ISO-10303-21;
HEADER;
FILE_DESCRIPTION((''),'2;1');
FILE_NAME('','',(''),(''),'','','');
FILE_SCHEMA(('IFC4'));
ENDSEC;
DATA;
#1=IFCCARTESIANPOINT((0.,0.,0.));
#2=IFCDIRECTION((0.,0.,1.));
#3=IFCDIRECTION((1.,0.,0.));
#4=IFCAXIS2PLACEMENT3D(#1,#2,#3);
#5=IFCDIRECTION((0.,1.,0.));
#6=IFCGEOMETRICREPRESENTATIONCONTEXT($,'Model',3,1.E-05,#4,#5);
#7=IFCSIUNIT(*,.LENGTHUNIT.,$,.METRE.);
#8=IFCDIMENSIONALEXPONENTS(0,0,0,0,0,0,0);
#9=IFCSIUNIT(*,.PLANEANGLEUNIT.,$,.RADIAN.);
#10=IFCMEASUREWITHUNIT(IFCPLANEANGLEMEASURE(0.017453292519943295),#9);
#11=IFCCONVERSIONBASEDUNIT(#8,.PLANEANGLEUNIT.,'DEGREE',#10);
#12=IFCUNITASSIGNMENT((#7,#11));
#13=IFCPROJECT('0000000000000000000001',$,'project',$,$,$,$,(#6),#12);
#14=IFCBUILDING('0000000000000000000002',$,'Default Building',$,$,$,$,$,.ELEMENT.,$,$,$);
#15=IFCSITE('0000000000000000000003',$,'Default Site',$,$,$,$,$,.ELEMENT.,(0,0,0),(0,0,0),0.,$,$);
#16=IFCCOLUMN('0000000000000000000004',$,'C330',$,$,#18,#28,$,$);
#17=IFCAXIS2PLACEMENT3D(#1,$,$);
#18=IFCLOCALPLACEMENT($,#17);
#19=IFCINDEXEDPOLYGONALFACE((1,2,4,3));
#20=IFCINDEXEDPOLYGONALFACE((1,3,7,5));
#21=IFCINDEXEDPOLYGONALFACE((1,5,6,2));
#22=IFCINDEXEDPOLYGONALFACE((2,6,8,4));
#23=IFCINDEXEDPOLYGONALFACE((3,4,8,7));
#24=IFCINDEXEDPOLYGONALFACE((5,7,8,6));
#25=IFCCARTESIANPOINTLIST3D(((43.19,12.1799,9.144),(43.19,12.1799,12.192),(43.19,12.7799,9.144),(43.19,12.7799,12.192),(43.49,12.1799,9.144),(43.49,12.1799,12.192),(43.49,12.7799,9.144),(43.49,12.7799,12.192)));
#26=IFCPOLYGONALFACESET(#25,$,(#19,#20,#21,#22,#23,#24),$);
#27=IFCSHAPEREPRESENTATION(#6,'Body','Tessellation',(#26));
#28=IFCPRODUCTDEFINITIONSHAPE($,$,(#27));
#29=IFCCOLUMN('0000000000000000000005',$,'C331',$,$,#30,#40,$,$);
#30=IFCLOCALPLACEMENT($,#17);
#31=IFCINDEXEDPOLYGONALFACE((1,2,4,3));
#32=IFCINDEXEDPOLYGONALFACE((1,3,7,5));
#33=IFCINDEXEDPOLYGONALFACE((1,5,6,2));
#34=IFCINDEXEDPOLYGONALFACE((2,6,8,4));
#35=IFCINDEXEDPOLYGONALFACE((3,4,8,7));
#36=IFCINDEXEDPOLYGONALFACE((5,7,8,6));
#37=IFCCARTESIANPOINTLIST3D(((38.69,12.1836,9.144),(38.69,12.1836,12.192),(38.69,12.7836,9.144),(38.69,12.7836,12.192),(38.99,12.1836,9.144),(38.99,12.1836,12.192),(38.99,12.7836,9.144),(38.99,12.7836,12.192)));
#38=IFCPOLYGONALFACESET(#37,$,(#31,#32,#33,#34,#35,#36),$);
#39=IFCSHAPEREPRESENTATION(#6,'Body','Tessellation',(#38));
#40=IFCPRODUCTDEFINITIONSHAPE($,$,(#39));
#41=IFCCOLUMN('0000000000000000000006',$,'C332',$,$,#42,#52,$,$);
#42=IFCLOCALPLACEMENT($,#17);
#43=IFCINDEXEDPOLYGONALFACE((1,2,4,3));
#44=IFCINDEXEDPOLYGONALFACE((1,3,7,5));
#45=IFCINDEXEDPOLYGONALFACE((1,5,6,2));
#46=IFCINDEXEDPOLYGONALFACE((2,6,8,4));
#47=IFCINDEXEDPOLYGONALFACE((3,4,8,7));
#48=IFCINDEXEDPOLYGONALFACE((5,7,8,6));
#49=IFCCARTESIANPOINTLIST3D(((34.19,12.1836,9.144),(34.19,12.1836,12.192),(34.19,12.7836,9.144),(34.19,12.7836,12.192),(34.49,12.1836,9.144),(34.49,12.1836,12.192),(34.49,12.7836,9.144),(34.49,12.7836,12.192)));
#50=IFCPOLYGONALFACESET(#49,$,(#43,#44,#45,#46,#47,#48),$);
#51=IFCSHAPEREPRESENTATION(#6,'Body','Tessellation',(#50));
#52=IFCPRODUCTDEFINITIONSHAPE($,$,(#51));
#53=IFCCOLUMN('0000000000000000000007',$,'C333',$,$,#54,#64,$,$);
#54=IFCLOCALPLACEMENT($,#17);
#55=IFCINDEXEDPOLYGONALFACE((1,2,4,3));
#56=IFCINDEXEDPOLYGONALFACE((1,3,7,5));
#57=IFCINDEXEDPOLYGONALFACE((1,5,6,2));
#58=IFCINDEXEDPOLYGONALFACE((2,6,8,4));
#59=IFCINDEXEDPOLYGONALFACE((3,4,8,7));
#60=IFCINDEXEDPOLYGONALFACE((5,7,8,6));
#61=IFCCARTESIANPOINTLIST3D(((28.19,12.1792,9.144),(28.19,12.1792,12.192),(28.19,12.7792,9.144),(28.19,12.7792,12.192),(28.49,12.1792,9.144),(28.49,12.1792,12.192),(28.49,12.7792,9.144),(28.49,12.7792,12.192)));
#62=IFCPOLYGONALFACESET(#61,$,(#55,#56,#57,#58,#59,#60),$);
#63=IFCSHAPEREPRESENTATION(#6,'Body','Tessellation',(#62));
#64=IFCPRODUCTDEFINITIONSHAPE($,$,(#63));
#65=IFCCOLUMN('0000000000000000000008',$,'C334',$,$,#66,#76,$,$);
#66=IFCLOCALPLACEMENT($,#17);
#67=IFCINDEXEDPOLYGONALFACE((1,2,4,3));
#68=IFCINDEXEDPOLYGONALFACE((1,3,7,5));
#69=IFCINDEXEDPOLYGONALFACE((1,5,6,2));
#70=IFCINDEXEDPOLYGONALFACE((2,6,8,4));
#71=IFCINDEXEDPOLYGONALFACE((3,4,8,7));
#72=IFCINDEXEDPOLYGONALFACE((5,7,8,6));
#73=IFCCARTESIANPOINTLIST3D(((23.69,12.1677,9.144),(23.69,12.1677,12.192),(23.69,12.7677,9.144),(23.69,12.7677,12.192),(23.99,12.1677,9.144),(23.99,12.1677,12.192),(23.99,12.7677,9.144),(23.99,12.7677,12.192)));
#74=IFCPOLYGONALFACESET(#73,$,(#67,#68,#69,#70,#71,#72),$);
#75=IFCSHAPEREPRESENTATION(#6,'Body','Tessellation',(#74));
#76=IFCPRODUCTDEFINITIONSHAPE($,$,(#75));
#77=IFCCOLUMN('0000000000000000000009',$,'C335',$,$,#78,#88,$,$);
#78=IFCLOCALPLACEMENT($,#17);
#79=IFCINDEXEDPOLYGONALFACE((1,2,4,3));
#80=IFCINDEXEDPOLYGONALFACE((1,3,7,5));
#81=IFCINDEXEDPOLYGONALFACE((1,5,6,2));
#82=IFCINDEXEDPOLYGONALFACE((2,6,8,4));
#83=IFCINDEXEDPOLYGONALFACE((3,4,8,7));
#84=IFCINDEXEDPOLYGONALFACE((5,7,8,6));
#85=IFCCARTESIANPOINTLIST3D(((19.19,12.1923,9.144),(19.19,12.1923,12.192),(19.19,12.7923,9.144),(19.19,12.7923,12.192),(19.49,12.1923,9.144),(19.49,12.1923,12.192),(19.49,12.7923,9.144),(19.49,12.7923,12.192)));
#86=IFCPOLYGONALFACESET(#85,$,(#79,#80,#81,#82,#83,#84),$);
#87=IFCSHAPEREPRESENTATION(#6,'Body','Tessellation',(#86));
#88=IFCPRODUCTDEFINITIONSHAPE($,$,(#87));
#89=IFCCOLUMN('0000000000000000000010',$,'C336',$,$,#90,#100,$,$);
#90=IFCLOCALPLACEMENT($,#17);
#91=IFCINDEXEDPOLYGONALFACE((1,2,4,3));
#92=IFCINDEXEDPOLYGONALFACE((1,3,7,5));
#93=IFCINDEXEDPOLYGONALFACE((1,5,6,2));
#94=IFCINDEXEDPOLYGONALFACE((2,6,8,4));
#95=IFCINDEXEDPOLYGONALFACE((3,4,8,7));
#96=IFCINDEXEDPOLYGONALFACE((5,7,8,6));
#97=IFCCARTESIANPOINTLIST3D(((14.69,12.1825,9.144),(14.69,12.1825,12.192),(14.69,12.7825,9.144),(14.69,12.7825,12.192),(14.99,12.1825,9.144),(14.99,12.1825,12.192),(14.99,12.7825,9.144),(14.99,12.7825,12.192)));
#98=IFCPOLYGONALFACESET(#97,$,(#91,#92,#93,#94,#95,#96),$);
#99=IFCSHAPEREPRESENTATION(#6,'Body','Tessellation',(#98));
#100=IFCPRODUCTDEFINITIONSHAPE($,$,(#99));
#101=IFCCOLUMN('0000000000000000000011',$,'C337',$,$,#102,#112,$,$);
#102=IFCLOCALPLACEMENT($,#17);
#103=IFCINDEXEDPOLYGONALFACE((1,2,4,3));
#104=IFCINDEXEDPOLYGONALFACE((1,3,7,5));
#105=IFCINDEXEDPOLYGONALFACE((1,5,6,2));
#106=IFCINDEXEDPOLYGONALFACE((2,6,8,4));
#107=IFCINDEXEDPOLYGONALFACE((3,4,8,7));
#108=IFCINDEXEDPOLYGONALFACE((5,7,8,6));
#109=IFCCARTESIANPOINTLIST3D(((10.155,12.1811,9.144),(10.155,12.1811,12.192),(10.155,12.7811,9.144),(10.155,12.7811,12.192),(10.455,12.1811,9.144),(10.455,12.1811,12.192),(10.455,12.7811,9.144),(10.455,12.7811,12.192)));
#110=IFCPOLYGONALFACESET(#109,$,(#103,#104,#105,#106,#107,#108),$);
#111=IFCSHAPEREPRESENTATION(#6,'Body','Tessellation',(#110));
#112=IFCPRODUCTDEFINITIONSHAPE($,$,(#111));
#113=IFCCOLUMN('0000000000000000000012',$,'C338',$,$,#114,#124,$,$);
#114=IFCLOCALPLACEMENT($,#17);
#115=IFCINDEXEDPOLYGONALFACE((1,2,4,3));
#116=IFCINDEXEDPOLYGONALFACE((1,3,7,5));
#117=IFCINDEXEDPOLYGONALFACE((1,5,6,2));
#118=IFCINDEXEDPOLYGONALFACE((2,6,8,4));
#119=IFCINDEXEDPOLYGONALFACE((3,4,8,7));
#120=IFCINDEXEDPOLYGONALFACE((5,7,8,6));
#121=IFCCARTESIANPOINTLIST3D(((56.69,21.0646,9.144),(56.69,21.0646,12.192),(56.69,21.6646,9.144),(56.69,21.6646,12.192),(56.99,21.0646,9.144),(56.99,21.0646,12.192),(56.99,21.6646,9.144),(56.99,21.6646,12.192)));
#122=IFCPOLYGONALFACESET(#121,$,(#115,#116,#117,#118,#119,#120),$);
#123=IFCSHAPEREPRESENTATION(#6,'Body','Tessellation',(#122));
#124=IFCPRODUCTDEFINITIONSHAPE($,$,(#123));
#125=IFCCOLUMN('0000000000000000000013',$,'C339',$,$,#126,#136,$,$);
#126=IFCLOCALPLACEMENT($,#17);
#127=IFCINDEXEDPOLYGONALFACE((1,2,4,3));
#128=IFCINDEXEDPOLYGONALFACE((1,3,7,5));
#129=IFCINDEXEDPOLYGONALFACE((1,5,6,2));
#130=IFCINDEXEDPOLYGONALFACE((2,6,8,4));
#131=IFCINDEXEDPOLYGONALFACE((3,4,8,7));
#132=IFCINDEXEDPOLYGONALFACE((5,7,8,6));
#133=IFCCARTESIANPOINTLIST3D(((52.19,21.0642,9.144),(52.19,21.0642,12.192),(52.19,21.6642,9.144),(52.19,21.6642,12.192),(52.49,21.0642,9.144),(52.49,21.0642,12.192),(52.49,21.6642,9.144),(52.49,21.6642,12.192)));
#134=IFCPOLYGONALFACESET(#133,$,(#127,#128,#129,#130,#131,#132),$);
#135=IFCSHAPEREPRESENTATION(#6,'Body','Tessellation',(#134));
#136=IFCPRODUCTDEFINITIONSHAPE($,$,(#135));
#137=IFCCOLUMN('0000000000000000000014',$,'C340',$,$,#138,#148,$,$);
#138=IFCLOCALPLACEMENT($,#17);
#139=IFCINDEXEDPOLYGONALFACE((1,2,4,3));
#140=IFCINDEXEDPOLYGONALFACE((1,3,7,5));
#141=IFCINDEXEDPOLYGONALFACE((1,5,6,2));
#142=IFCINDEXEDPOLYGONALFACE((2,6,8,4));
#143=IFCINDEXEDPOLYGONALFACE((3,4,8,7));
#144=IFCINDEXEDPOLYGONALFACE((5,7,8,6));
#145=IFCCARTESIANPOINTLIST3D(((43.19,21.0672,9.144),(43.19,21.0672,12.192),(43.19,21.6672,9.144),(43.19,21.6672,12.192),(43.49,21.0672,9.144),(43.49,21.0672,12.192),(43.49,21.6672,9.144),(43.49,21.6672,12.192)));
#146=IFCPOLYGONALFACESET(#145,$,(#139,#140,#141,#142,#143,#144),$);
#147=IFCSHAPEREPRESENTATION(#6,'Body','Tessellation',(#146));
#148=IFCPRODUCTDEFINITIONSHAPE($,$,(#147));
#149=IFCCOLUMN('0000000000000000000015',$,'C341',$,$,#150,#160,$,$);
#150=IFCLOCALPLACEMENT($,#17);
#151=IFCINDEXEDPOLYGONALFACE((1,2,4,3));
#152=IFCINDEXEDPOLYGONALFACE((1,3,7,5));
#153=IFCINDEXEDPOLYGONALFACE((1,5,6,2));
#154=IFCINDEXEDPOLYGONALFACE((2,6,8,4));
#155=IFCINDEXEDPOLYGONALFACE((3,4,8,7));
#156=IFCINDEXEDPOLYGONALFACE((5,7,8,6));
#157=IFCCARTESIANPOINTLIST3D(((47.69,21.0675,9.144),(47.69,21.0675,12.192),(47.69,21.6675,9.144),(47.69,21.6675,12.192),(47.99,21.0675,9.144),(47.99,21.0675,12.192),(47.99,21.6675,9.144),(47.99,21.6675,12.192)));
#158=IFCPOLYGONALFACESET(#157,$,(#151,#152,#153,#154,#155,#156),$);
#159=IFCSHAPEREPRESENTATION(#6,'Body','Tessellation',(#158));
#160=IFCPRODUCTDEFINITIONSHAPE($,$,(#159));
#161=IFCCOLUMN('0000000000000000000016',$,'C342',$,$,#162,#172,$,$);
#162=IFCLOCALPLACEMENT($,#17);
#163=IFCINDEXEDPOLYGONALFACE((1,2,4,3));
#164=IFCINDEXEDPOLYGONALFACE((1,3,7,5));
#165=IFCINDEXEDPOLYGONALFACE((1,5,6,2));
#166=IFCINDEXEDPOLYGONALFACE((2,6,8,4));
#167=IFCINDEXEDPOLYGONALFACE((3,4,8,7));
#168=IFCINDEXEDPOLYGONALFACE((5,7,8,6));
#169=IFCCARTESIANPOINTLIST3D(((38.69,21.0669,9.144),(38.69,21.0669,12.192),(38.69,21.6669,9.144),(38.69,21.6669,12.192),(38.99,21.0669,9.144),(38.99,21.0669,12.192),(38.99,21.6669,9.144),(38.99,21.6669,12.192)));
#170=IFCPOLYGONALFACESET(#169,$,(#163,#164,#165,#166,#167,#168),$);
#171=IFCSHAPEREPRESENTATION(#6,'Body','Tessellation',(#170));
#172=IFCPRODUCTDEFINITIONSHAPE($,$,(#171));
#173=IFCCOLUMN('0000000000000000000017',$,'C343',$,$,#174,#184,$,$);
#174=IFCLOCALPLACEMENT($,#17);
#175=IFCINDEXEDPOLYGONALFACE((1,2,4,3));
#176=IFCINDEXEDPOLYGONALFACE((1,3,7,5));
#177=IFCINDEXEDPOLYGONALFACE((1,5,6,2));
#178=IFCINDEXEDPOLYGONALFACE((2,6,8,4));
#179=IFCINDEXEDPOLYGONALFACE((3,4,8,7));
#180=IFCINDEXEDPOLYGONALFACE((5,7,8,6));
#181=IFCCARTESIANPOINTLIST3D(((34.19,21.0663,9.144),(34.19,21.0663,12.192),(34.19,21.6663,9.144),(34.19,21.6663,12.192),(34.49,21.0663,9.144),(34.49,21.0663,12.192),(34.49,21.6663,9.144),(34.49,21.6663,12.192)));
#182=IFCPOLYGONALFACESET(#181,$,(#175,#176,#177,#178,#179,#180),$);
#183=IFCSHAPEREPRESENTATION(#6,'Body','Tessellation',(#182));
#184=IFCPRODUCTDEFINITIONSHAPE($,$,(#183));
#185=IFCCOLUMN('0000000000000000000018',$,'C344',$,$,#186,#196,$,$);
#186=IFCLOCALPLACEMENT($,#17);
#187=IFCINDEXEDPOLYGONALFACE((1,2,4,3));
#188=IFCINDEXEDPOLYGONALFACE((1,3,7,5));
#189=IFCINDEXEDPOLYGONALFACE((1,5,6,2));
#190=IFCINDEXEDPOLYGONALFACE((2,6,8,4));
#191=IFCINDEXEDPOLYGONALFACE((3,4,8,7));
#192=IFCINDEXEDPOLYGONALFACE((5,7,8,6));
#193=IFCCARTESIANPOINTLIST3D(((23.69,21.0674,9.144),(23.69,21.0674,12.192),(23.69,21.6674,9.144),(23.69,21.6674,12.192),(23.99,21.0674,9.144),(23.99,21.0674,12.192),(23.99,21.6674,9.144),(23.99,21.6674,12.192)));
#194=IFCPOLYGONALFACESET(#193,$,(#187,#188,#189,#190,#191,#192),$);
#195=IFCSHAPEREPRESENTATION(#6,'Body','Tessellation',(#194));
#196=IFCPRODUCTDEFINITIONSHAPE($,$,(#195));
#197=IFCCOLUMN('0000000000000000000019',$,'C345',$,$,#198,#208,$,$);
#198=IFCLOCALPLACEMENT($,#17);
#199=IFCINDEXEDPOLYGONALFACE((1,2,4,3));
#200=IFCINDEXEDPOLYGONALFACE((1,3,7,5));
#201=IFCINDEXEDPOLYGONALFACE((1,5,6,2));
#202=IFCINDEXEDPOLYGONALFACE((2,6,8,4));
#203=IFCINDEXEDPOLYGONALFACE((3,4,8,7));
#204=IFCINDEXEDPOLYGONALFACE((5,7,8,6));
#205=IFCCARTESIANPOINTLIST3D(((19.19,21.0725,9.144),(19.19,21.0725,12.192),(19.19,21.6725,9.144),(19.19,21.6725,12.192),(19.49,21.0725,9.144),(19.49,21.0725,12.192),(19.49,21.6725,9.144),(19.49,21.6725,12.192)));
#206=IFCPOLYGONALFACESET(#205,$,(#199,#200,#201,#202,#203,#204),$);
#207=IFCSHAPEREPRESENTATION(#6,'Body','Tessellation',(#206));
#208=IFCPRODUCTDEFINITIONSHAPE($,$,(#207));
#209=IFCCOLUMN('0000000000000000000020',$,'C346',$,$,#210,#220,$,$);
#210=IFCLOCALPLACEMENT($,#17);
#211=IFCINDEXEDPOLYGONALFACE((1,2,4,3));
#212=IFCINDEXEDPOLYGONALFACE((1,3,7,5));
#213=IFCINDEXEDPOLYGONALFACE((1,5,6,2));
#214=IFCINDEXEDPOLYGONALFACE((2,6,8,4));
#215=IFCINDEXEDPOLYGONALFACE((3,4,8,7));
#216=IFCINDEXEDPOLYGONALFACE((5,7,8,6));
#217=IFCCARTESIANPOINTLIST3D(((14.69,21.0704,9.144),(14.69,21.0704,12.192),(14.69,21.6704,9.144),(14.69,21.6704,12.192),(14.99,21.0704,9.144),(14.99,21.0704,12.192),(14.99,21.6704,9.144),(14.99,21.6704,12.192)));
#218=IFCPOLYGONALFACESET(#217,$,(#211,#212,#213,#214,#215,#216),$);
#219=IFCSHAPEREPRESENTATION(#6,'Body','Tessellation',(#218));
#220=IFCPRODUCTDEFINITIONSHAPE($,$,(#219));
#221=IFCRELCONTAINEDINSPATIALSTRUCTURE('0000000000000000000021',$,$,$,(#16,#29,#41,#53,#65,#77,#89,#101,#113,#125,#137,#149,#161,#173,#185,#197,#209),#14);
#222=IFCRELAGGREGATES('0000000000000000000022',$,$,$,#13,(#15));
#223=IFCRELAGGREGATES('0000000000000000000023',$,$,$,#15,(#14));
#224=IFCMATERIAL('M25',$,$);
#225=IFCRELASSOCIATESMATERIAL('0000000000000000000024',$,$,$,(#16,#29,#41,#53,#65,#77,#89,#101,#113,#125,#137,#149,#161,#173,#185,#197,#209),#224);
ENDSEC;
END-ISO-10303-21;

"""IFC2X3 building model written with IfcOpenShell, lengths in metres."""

from ifc_helpers import new_model, entity, si_unit, converted_unit, direction, frame, frame_2d, origin_with_axes, place, context, project, spatial, rectangle, extrude, material, element, save


model = new_model("IFC2X3")

# Units and contexts
model_context = context("Model", 3, precision=1e-05, world=origin_with_axes(), true_north=direction((0.0, 1.0, 0.0)))
ifc_project = project(units=[si_unit("LENGTHUNIT", "METRE"), converted_unit("PLANEANGLEUNIT", "DEGREE", entity("IfcPlaneAngleMeasure", 0.017453292519943295), si_unit("PLANEANGLEUNIT", "RADIAN"), dimensions=[0, 0, 0, 0, 0, 0, 0])], contexts=[model_context])

# Site, building
site = spatial("IfcSite", under=ifc_project, Name="Default Site", CompositionType="ELEMENT", RefLatitude=(0, 0, 0), RefLongitude=(0, 0, 0), RefElevation=0.0)
building = spatial("IfcBuilding", under=site, Name="Default Building", CompositionType="ELEMENT")

# Columns
ifc_material = material(Name="M25")
placement = place(None, origin_with_axes())
element("IfcColumn", 1, at=placement, inside=building, material=ifc_material, Name="C330", context=model_context, shape_type="SweptSolid", body=[
    extrude(rectangle(XDim=0.3, YDim=0.6, at=frame_2d((0.0, 0.0), x_axis=(1.0, 0.0, 0.0))), frame((43.34, 12.4799, 9.144), z_axis=(0.0, 0.0, 1.0), x_axis=(1.0, 0.0, 0.0)), (0.0, 0.0, 1.0), 3.048),
])
element("IfcColumn", 2, at=placement, inside=building, material=ifc_material, Name="C331", context=model_context, shape_type="SweptSolid", body=[
    extrude(rectangle(XDim=0.3, YDim=0.6, at=frame_2d((0.0, 0.0), x_axis=(1.0, 0.0, 0.0))), frame((38.84, 12.4836, 9.144), z_axis=(0.0, 0.0, 1.0), x_axis=(1.0, 0.0, 0.0)), (0.0, 0.0, 1.0), 3.048),
])
element("IfcColumn", 3, at=placement, inside=building, material=ifc_material, Name="C332", context=model_context, shape_type="SweptSolid", body=[
    extrude(rectangle(XDim=0.3, YDim=0.6, at=frame_2d((0.0, 0.0), x_axis=(1.0, 0.0, 0.0))), frame((34.34, 12.4836, 9.144), z_axis=(0.0, 0.0, 1.0), x_axis=(1.0, 0.0, 0.0)), (0.0, 0.0, 1.0), 3.048),
])
element("IfcColumn", 4, at=placement, inside=building, material=ifc_material, Name="C333", context=model_context, shape_type="SweptSolid", body=[
    extrude(rectangle(XDim=0.3, YDim=0.6, at=frame_2d((0.0, 0.0), x_axis=(1.0, 0.0, 0.0))), frame((28.34, 12.4792, 9.144), z_axis=(0.0, 0.0, 1.0), x_axis=(1.0, 0.0, 0.0)), (0.0, 0.0, 1.0), 3.048),
])
element("IfcColumn", 5, at=placement, inside=building, material=ifc_material, Name="C334", context=model_context, shape_type="SweptSolid", body=[
    extrude(rectangle(XDim=0.3, YDim=0.6, at=frame_2d((0.0, 0.0), x_axis=(1.0, 0.0, 0.0))), frame((23.84, 12.4677, 9.144), z_axis=(0.0, 0.0, 1.0), x_axis=(1.0, 0.0, 0.0)), (0.0, 0.0, 1.0), 3.048),
])
element("IfcColumn", 6, at=placement, inside=building, material=ifc_material, Name="C335", context=model_context, shape_type="SweptSolid", body=[
    extrude(rectangle(XDim=0.3, YDim=0.6, at=frame_2d((0.0, 0.0), x_axis=(1.0, 0.0, 0.0))), frame((19.34, 12.4923, 9.144), z_axis=(0.0, 0.0, 1.0), x_axis=(1.0, 0.0, 0.0)), (0.0, 0.0, 1.0), 3.048),
])
element("IfcColumn", 7, at=placement, inside=building, material=ifc_material, Name="C336", context=model_context, shape_type="SweptSolid", body=[
    extrude(rectangle(XDim=0.3, YDim=0.6, at=frame_2d((0.0, 0.0), x_axis=(1.0, 0.0, 0.0))), frame((14.84, 12.4825, 9.144), z_axis=(0.0, 0.0, 1.0), x_axis=(1.0, 0.0, 0.0)), (0.0, 0.0, 1.0), 3.048),
])
element("IfcColumn", 8, at=placement, inside=building, material=ifc_material, Name="C337", context=model_context, shape_type="SweptSolid", body=[
    extrude(rectangle(XDim=0.3, YDim=0.6, at=frame_2d((0.0, 0.0), x_axis=(1.0, 0.0, 0.0))), frame((10.305, 12.4811, 9.144), z_axis=(0.0, 0.0, 1.0), x_axis=(1.0, 0.0, 0.0)), (0.0, 0.0, 1.0), 3.048),
])
element("IfcColumn", 9, at=placement, inside=building, material=ifc_material, Name="C338", context=model_context, shape_type="SweptSolid", body=[
    extrude(rectangle(XDim=0.3, YDim=0.6, at=frame_2d((0.0, 0.0), x_axis=(1.0, 0.0, 0.0))), frame((56.84, 21.3646, 9.144), z_axis=(0.0, 0.0, 1.0), x_axis=(1.0, 0.0, 0.0)), (0.0, 0.0, 1.0), 3.048),
])
element("IfcColumn", 10, at=placement, inside=building, material=ifc_material, Name="C339", context=model_context, shape_type="SweptSolid", body=[
    extrude(rectangle(XDim=0.3, YDim=0.6, at=frame_2d((0.0, 0.0), x_axis=(1.0, 0.0, 0.0))), frame((52.34, 21.3642, 9.144), z_axis=(0.0, 0.0, 1.0), x_axis=(1.0, 0.0, 0.0)), (0.0, 0.0, 1.0), 3.048),
])
element("IfcColumn", 11, at=placement, inside=building, material=ifc_material, Name="C340", context=model_context, shape_type="SweptSolid", body=[
    extrude(rectangle(XDim=0.3, YDim=0.6, at=frame_2d((0.0, 0.0), x_axis=(1.0, 0.0, 0.0))), frame((43.34, 21.3672, 9.144), z_axis=(0.0, 0.0, 1.0), x_axis=(1.0, 0.0, 0.0)), (0.0, 0.0, 1.0), 3.048),
])
element("IfcColumn", 12, at=placement, inside=building, material=ifc_material, Name="C341", context=model_context, shape_type="SweptSolid", body=[
    extrude(rectangle(XDim=0.3, YDim=0.6, at=frame_2d((0.0, 0.0), x_axis=(1.0, 0.0, 0.0))), frame((47.84, 21.3675, 9.144), z_axis=(0.0, 0.0, 1.0), x_axis=(1.0, 0.0, 0.0)), (0.0, 0.0, 1.0), 3.048),
])
element("IfcColumn", 13, at=placement, inside=building, material=ifc_material, Name="C342", context=model_context, shape_type="SweptSolid", body=[
    extrude(rectangle(XDim=0.3, YDim=0.6, at=frame_2d((0.0, 0.0), x_axis=(1.0, 0.0, 0.0))), frame((38.84, 21.3669, 9.144), z_axis=(0.0, 0.0, 1.0), x_axis=(1.0, 0.0, 0.0)), (0.0, 0.0, 1.0), 3.048),
])
element("IfcColumn", 14, at=placement, inside=building, material=ifc_material, Name="C343", context=model_context, shape_type="SweptSolid", body=[
    extrude(rectangle(XDim=0.3, YDim=0.6, at=frame_2d((0.0, 0.0), x_axis=(1.0, 0.0, 0.0))), frame((34.34, 21.3663, 9.144), z_axis=(0.0, 0.0, 1.0), x_axis=(1.0, 0.0, 0.0)), (0.0, 0.0, 1.0), 3.048),
])
element("IfcColumn", 15, at=placement, inside=building, material=ifc_material, Name="C344", context=model_context, shape_type="SweptSolid", body=[
    extrude(rectangle(XDim=0.3, YDim=0.6, at=frame_2d((0.0, 0.0), x_axis=(1.0, 0.0, 0.0))), frame((23.84, 21.3674, 9.144), z_axis=(0.0, 0.0, 1.0), x_axis=(1.0, 0.0, 0.0)), (0.0, 0.0, 1.0), 3.048),
])
element("IfcColumn", 16, at=placement, inside=building, material=ifc_material, Name="C345", context=model_context, shape_type="SweptSolid", body=[
    extrude(rectangle(XDim=0.3, YDim=0.6, at=frame_2d((0.0, 0.0), x_axis=(1.0, 0.0, 0.0))), frame((19.34, 21.3725, 9.144), z_axis=(0.0, 0.0, 1.0), x_axis=(1.0, 0.0, 0.0)), (0.0, 0.0, 1.0), 3.048),
])
element("IfcColumn", 17, at=placement, inside=building, material=ifc_material, Name="C346", context=model_context, shape_type="SweptSolid", body=[
    extrude(rectangle(XDim=0.3, YDim=0.6, at=frame_2d((0.0, 0.0), x_axis=(1.0, 0.0, 0.0))), frame((14.84, 21.3704, 9.144), z_axis=(0.0, 0.0, 1.0), x_axis=(1.0, 0.0, 0.0)), (0.0, 0.0, 1.0), 3.048),
])

save(model, "model.ifc")
